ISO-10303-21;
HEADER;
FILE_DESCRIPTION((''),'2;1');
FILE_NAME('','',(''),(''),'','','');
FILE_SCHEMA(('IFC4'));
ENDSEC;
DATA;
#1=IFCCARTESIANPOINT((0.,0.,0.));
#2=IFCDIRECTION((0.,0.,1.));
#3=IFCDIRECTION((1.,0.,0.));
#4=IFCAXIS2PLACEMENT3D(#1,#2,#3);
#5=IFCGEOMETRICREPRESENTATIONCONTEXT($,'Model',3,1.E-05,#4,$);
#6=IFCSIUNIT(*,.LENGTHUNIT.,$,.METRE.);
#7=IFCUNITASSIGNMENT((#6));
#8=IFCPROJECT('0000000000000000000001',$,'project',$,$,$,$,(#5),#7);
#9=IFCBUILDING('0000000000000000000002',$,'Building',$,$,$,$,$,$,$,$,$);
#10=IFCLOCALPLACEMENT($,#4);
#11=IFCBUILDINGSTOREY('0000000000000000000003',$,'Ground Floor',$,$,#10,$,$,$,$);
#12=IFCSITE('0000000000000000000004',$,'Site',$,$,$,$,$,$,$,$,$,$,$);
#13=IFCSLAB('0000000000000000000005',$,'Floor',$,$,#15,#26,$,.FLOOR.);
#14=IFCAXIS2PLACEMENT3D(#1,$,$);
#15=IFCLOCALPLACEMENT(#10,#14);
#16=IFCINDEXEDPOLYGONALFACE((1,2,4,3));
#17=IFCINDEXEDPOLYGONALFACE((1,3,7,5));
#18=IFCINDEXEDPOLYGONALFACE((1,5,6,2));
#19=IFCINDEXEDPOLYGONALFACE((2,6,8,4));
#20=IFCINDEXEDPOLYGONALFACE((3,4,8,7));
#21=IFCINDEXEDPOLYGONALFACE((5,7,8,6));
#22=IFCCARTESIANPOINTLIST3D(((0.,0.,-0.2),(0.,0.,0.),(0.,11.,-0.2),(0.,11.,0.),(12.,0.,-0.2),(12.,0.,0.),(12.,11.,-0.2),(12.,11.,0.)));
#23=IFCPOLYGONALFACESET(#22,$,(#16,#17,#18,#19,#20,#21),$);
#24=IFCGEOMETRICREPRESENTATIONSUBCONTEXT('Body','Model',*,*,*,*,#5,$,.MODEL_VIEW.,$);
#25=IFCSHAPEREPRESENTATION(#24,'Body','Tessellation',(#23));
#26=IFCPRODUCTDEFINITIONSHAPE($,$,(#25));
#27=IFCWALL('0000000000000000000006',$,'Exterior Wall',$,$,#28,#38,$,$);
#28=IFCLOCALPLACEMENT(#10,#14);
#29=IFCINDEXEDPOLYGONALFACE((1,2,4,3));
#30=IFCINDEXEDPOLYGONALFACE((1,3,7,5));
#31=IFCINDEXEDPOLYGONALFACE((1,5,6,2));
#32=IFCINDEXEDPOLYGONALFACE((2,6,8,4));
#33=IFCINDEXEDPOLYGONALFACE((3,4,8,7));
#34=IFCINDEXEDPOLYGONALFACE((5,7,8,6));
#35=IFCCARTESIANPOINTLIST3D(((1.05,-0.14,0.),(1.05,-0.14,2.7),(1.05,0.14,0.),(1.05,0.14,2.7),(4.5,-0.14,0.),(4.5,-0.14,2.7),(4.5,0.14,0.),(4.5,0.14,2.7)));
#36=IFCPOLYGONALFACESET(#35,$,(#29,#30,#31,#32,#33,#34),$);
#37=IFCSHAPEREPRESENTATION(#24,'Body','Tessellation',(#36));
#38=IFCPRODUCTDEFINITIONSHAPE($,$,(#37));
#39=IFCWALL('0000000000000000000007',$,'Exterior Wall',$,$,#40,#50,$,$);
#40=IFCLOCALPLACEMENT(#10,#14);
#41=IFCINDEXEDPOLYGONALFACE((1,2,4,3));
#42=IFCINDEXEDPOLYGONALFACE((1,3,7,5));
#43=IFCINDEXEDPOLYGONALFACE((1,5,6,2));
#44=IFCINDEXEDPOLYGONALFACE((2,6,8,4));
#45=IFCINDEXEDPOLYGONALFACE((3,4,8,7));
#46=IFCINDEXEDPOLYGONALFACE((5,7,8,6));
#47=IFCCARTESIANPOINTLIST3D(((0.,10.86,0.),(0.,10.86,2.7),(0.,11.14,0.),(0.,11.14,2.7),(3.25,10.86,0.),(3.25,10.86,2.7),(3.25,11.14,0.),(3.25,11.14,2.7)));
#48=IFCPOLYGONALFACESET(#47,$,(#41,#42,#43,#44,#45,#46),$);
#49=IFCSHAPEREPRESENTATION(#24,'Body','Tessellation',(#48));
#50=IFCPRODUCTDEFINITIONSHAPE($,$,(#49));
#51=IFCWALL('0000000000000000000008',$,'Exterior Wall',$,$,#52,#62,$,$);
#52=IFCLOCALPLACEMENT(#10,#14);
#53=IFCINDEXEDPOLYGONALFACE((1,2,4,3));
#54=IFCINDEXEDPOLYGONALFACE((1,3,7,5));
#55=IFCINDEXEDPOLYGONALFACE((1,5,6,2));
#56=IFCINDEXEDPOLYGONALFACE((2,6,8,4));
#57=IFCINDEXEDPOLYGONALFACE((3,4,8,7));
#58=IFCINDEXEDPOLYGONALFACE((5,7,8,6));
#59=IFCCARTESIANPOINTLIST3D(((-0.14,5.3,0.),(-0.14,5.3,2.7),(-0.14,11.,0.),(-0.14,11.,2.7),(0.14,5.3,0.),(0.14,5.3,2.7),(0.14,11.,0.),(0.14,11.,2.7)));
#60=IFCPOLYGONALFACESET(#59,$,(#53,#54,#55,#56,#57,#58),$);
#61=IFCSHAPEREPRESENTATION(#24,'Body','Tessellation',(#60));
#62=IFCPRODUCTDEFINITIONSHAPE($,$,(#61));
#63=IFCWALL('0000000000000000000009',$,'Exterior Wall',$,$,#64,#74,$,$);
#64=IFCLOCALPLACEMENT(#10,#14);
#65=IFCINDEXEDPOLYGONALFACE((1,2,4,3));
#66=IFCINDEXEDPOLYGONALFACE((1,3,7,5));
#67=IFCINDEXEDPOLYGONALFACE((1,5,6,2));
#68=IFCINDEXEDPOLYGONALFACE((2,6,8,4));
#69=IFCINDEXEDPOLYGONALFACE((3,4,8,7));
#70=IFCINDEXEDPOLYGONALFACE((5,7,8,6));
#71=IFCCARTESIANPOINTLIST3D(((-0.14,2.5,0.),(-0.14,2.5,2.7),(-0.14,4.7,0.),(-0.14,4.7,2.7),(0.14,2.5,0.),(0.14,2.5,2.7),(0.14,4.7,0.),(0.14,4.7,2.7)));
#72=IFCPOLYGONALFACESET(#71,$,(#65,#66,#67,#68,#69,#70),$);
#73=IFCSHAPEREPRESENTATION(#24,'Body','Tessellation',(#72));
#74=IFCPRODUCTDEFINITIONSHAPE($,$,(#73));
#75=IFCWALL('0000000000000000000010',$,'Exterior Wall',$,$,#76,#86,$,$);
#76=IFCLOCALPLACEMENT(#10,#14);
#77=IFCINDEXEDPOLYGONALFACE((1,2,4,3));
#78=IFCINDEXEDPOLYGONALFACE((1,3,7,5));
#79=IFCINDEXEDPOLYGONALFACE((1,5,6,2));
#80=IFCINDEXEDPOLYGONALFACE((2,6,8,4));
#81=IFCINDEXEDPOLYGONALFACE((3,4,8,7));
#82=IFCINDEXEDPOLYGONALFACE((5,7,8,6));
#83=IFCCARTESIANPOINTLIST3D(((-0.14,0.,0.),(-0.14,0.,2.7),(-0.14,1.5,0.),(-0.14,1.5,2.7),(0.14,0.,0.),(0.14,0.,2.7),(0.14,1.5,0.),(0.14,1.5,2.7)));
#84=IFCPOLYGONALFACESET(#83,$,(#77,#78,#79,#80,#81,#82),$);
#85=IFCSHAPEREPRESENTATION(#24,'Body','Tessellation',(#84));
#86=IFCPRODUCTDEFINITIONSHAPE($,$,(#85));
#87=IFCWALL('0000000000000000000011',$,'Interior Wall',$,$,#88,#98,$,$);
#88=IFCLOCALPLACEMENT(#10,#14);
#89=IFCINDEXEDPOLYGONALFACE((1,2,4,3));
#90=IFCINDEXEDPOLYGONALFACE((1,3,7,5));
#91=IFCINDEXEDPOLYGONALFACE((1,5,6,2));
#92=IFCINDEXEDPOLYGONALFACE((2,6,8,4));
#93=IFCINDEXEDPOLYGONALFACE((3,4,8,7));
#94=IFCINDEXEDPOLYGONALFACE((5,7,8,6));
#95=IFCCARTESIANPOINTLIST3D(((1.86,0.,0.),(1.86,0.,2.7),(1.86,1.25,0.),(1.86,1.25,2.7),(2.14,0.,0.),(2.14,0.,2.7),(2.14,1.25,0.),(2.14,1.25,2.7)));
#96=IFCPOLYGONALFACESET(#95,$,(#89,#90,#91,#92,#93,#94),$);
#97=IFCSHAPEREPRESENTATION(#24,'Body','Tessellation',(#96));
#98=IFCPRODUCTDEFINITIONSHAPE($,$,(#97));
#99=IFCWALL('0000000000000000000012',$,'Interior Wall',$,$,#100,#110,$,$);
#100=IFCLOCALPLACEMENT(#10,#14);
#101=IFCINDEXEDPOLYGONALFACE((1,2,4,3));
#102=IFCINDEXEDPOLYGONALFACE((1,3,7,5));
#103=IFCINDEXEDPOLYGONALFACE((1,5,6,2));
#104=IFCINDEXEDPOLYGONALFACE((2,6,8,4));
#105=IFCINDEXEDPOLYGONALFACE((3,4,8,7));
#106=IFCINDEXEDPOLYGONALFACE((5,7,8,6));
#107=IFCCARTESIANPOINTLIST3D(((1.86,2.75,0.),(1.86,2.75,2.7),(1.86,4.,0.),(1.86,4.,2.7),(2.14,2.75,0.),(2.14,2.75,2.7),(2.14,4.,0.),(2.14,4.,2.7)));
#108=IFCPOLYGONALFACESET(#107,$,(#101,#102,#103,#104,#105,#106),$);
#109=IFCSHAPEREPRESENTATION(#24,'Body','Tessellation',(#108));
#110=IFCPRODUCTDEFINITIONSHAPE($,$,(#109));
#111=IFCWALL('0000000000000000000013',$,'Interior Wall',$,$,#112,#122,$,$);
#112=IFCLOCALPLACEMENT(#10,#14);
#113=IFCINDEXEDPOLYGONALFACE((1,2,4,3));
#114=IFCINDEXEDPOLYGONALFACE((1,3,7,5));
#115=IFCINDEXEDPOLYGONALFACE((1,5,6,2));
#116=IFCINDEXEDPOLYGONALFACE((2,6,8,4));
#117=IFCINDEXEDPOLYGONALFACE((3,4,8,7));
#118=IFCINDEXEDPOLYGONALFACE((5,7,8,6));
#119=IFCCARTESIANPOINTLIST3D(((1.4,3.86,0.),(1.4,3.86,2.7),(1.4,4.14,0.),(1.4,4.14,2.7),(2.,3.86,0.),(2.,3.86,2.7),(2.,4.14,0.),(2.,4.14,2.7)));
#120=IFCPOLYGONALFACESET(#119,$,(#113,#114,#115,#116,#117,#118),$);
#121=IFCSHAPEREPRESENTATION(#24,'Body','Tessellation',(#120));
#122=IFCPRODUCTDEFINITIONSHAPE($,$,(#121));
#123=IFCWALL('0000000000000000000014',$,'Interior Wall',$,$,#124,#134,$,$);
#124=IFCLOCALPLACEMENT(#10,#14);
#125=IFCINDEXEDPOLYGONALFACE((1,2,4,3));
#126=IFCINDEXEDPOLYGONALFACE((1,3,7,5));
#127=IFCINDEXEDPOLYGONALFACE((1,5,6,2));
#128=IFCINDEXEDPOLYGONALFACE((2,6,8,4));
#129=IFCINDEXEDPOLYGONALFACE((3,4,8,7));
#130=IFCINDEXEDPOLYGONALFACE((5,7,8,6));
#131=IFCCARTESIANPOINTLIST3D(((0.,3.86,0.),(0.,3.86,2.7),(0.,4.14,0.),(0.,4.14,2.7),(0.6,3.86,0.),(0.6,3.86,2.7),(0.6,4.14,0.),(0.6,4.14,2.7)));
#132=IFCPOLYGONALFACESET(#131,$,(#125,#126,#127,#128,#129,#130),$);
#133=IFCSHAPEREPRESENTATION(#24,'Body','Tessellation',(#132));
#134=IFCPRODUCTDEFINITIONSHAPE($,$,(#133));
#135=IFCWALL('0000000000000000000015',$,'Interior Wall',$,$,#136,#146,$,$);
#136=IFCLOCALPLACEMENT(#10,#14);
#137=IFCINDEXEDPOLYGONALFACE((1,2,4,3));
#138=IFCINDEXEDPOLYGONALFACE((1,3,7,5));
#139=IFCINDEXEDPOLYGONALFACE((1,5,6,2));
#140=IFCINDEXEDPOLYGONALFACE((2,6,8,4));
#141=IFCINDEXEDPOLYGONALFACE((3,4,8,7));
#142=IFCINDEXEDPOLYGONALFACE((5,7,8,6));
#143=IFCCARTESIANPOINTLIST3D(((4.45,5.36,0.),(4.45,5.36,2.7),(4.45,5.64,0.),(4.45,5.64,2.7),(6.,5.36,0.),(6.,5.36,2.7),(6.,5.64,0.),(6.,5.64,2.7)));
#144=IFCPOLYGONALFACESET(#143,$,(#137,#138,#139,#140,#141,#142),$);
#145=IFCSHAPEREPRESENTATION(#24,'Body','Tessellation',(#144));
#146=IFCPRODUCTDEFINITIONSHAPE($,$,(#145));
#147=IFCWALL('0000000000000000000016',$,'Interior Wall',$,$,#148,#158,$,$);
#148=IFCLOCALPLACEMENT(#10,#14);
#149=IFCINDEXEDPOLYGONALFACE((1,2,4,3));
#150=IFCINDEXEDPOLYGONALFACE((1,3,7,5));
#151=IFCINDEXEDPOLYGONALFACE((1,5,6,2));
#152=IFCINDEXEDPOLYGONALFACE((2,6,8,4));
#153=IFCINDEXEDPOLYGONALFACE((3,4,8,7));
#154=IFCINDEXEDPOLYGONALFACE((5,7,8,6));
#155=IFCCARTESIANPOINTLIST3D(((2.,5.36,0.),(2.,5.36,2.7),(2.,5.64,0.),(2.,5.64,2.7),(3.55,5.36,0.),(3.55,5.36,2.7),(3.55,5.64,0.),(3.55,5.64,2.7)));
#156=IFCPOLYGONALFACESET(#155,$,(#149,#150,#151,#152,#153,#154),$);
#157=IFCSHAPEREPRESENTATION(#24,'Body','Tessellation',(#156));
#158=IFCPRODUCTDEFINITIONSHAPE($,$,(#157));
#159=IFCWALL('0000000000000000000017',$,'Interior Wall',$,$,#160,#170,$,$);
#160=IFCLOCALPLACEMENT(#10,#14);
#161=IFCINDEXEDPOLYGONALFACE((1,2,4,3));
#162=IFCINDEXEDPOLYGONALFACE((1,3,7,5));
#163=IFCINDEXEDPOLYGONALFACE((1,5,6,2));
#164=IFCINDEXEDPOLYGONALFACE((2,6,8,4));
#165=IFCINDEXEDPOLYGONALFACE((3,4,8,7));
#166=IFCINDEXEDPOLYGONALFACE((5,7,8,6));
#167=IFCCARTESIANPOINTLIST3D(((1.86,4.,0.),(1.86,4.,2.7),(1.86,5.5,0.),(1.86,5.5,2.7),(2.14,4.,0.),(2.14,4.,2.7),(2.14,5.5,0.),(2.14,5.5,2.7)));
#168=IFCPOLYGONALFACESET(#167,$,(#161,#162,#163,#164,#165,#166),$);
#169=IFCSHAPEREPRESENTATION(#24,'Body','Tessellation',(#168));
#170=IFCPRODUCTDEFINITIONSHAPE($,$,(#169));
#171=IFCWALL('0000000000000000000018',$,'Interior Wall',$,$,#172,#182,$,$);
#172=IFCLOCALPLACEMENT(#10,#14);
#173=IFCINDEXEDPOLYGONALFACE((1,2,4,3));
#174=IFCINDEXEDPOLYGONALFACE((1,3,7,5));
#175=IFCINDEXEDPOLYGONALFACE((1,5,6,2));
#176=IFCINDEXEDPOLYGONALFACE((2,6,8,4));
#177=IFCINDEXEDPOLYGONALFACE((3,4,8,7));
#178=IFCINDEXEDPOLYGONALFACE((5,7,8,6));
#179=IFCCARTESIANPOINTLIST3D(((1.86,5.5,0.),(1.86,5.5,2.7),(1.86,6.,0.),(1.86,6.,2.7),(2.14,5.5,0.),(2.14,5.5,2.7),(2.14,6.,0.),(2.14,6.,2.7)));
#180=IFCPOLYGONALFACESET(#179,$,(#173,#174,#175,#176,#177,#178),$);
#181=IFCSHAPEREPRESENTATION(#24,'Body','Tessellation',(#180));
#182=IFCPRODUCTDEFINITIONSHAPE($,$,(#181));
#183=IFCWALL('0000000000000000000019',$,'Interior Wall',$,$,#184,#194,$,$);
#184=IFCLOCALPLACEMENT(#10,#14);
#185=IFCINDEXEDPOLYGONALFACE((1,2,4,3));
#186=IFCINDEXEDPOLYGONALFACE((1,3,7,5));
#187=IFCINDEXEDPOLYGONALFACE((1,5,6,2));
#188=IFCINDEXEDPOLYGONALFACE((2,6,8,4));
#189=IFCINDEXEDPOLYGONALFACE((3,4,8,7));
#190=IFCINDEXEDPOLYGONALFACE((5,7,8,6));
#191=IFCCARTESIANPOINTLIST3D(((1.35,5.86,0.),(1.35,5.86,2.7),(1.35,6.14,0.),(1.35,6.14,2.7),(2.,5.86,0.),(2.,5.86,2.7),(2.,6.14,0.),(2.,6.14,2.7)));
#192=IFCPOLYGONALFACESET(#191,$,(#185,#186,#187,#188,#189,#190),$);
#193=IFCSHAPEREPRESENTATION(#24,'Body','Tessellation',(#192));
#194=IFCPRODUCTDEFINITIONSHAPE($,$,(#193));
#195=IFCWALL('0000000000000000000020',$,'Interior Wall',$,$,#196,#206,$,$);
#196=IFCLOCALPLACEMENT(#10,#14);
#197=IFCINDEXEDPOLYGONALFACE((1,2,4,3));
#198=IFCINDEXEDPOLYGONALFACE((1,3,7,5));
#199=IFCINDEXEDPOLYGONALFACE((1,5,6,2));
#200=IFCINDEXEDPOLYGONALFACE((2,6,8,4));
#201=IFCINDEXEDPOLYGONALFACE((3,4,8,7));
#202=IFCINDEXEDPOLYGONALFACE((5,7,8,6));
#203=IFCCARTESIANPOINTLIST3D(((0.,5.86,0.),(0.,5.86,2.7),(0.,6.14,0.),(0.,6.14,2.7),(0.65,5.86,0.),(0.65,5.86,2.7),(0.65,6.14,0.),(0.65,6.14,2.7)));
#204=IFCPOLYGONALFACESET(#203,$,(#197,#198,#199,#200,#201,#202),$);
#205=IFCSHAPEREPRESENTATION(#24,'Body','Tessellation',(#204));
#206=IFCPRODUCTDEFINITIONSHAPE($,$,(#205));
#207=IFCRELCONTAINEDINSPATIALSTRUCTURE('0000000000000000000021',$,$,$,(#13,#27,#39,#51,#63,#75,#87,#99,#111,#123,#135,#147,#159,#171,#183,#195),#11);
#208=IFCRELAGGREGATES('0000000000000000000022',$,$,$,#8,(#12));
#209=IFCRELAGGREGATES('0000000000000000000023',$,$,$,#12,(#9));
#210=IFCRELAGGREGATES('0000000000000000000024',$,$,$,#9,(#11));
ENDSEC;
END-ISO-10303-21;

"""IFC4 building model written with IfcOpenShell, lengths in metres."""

from ifc_helpers import new_model, si_unit, frame, origin_with_axes, place, context, subcontext, project, spatial, indexed_curve, outline, extrude, element, save


model = new_model("IFC4")

# Units and contexts
model_context = context("Model", 3, precision=1e-05, world=origin_with_axes())
body_context = subcontext(model_context, "Body", "Model", "MODEL_VIEW")
ifc_project = project(units=[si_unit("LENGTHUNIT", "METRE")], contexts=[model_context])

# Site, building, storey
site = spatial("IfcSite", under=ifc_project, Name="Site")
building = spatial("IfcBuilding", under=site, Name="Building")
storey_placement = place(None, origin_with_axes())
storey = spatial("IfcBuildingStorey", under=building, at=storey_placement, Name="Ground Floor")

# Slab
slab_placement = place(storey_placement, frame((0.0, 0.0, -0.2), z_axis=(0.0, 0.0, 1.0), x_axis=(1.0, 0.0, 0.0)))
element("IfcSlab", 1, at=slab_placement, inside=storey, Name="Floor", PredefinedType="FLOOR", context=body_context, shape_type="SweptSolid", body=[
    extrude(outline(indexed_curve([(0.0, 0.0), (12.0, 0.0), (12.0, 11.0), (0.0, 11.0)])), None, (0.0, 0.0, 1.0), 0.2),
])

# Walls
wall_1_placement = place(storey_placement, frame((1.05, 0.0, 0.0), z_axis=(0.0, 0.0, 1.0), x_axis=(1.0, 0.0, 0.0)))
element("IfcWall", 2, at=wall_1_placement, inside=storey, Name="Exterior Wall", context=body_context, shape_type="SweptSolid", body=[
    extrude(outline(indexed_curve([(0.0, 0.0), (0.0, 0.28), (3.45, 0.28), (3.45, 0.0), (0.0, 0.0)], self_intersect=False)), frame((0.0, -0.14, 0.0), z_axis=(0.0, 0.0, 1.0), x_axis=(1.0, 0.0, 0.0)), (0.0, 0.0, 1.0), 2.7),
])
wall_2_placement = place(storey_placement, frame((3.25, 11.0, 0.0), z_axis=(0.0, 0.0, 1.0), x_axis=(-1.0, 0.0, 0.0)))
element("IfcWall", 3, at=wall_2_placement, inside=storey, Name="Exterior Wall", context=body_context, shape_type="SweptSolid", body=[
    extrude(outline(indexed_curve([(0.0, 0.0), (0.0, 0.28), (3.25, 0.28), (3.25, 0.0), (0.0, 0.0)], self_intersect=False)), frame((0.0, -0.14, 0.0), z_axis=(0.0, 0.0, 1.0), x_axis=(1.0, 0.0, 0.0)), (0.0, 0.0, 1.0), 2.7),
])
wall_3_placement = place(storey_placement, frame((0.0, 11.0, 0.0), z_axis=(0.0, 0.0, 1.0), x_axis=(0.0, -1.0, 0.0)))
element("IfcWall", 4, at=wall_3_placement, inside=storey, Name="Exterior Wall", context=body_context, shape_type="SweptSolid", body=[
    extrude(outline(indexed_curve([(0.0, 0.0), (0.0, 0.28), (5.7, 0.28), (5.7, 0.0), (0.0, 0.0)], self_intersect=False)), frame((0.0, -0.14, 0.0), z_axis=(0.0, 0.0, 1.0), x_axis=(1.0, 0.0, 0.0)), (0.0, 0.0, 1.0), 2.7),
])
wall_4_placement = place(storey_placement, frame((0.0, 4.7, 0.0), z_axis=(0.0, 0.0, 1.0), x_axis=(0.0, -1.0, 0.0)))
element("IfcWall", 5, at=wall_4_placement, inside=storey, Name="Exterior Wall", context=body_context, shape_type="SweptSolid", body=[
    extrude(outline(indexed_curve([(0.0, 0.0), (0.0, 0.28), (2.2, 0.28), (2.2, 0.0), (0.0, 0.0)], self_intersect=False)), frame((0.0, -0.14, 0.0), z_axis=(0.0, 0.0, 1.0), x_axis=(1.0, 0.0, 0.0)), (0.0, 0.0, 1.0), 2.7),
])
wall_5_placement = place(storey_placement, frame((0.0, 1.5, 0.0), z_axis=(0.0, 0.0, 1.0), x_axis=(0.0, -1.0, 0.0)))
element("IfcWall", 6, at=wall_5_placement, inside=storey, Name="Exterior Wall", context=body_context, shape_type="SweptSolid", body=[
    extrude(outline(indexed_curve([(0.0, 0.0), (0.0, 0.28), (1.5, 0.28), (1.5, 0.0), (0.0, 0.0)], self_intersect=False)), frame((0.0, -0.14, 0.0), z_axis=(0.0, 0.0, 1.0), x_axis=(1.0, 0.0, 0.0)), (0.0, 0.0, 1.0), 2.7),
])
for number, where, z_axis, x_axis, name in (
    (7, (2.0, 0.0, 0.0), (0.0, 0.0, 1.0), (0.0, 1.0, 0.0), "Interior Wall"),
    (8, (2.0, 2.75, 0.0), (0.0, 0.0, 1.0), (0.0, 1.0, 0.0), "Interior Wall"),
):
    element("IfcWall", number, at=place(storey_placement, frame(where, z_axis=z_axis, x_axis=x_axis)), inside=storey, Name=name, context=body_context, shape_type="SweptSolid", body=[
        extrude(outline(indexed_curve([(0.0, 0.0), (0.0, 0.28), (1.25, 0.28), (1.25, 0.0), (0.0, 0.0)], self_intersect=False)), frame((0.0, -0.14, 0.0), z_axis=(0.0, 0.0, 1.0), x_axis=(1.0, 0.0, 0.0)), (0.0, 0.0, 1.0), 2.7),
    ])
for number, where, z_axis, x_axis, name in (
    (9, (2.0, 4.0, 0.0), (0.0, 0.0, 1.0), (-1.0, 0.0, 0.0), "Interior Wall"),
    (10, (0.6, 4.0, 0.0), (0.0, 0.0, 1.0), (-1.0, 0.0, 0.0), "Interior Wall"),
):
    element("IfcWall", number, at=place(storey_placement, frame(where, z_axis=z_axis, x_axis=x_axis)), inside=storey, Name=name, context=body_context, shape_type="SweptSolid", body=[
        extrude(outline(indexed_curve([(0.0, 0.0), (0.0, 0.28), (0.6, 0.28), (0.6, 0.0), (0.0, 0.0)], self_intersect=False)), frame((0.0, -0.14, 0.0), z_axis=(0.0, 0.0, 1.0), x_axis=(1.0, 0.0, 0.0)), (0.0, 0.0, 1.0), 2.7),
    ])
for number, where, z_axis, x_axis, name in (
    (11, (6.0, 5.5, 0.0), (0.0, 0.0, 1.0), (-1.0, 0.0, 0.0), "Interior Wall"),
    (12, (3.55, 5.5, 0.0), (0.0, 0.0, 1.0), (-1.0, 0.0, 0.0), "Interior Wall"),
):
    element("IfcWall", number, at=place(storey_placement, frame(where, z_axis=z_axis, x_axis=x_axis)), inside=storey, Name=name, context=body_context, shape_type="SweptSolid", body=[
        extrude(outline(indexed_curve([(0.0, 0.0), (0.0, 0.28), (1.55, 0.28), (1.55, 0.0), (0.0, 0.0)], self_intersect=False)), frame((0.0, -0.14, 0.0), z_axis=(0.0, 0.0, 1.0), x_axis=(1.0, 0.0, 0.0)), (0.0, 0.0, 1.0), 2.7),
    ])
wall_6_placement = place(storey_placement, frame((2.0, 5.5, 0.0), z_axis=(0.0, 0.0, 1.0), x_axis=(0.0, -1.0, 0.0)))
element("IfcWall", 13, at=wall_6_placement, inside=storey, Name="Interior Wall", context=body_context, shape_type="SweptSolid", body=[
    extrude(outline(indexed_curve([(0.0, 0.0), (0.0, 0.28), (1.5, 0.28), (1.5, 0.0), (0.0, 0.0)], self_intersect=False)), frame((0.0, -0.14, 0.0), z_axis=(0.0, 0.0, 1.0), x_axis=(1.0, 0.0, 0.0)), (0.0, 0.0, 1.0), 2.7),
])
wall_7_placement = place(storey_placement, frame((2.0, 5.5, 0.0), z_axis=(0.0, 0.0, 1.0), x_axis=(0.0, 1.0, 0.0)))
element("IfcWall", 14, at=wall_7_placement, inside=storey, Name="Interior Wall", context=body_context, shape_type="SweptSolid", body=[
    extrude(outline(indexed_curve([(0.0, 0.0), (0.0, 0.28), (0.5, 0.28), (0.5, 0.0), (0.0, 0.0)], self_intersect=False)), frame((0.0, -0.14, 0.0), z_axis=(0.0, 0.0, 1.0), x_axis=(1.0, 0.0, 0.0)), (0.0, 0.0, 1.0), 2.7),
])
for number, where, z_axis, x_axis, name in (
    (15, (2.0, 6.0, 0.0), (0.0, 0.0, 1.0), (-1.0, 0.0, 0.0), "Interior Wall"),
    (16, (0.65, 6.0, 0.0), (0.0, 0.0, 1.0), (-1.0, 0.0, 0.0), "Interior Wall"),
):
    element("IfcWall", number, at=place(storey_placement, frame(where, z_axis=z_axis, x_axis=x_axis)), inside=storey, Name=name, context=body_context, shape_type="SweptSolid", body=[
        extrude(outline(indexed_curve([(0.0, 0.0), (0.0, 0.28), (0.65, 0.28), (0.65, 0.0), (0.0, 0.0)], self_intersect=False)), frame((0.0, -0.14, 0.0), z_axis=(0.0, 0.0, 1.0), x_axis=(1.0, 0.0, 0.0)), (0.0, 0.0, 1.0), 2.7),
    ])

save(model, "model.ifc")
